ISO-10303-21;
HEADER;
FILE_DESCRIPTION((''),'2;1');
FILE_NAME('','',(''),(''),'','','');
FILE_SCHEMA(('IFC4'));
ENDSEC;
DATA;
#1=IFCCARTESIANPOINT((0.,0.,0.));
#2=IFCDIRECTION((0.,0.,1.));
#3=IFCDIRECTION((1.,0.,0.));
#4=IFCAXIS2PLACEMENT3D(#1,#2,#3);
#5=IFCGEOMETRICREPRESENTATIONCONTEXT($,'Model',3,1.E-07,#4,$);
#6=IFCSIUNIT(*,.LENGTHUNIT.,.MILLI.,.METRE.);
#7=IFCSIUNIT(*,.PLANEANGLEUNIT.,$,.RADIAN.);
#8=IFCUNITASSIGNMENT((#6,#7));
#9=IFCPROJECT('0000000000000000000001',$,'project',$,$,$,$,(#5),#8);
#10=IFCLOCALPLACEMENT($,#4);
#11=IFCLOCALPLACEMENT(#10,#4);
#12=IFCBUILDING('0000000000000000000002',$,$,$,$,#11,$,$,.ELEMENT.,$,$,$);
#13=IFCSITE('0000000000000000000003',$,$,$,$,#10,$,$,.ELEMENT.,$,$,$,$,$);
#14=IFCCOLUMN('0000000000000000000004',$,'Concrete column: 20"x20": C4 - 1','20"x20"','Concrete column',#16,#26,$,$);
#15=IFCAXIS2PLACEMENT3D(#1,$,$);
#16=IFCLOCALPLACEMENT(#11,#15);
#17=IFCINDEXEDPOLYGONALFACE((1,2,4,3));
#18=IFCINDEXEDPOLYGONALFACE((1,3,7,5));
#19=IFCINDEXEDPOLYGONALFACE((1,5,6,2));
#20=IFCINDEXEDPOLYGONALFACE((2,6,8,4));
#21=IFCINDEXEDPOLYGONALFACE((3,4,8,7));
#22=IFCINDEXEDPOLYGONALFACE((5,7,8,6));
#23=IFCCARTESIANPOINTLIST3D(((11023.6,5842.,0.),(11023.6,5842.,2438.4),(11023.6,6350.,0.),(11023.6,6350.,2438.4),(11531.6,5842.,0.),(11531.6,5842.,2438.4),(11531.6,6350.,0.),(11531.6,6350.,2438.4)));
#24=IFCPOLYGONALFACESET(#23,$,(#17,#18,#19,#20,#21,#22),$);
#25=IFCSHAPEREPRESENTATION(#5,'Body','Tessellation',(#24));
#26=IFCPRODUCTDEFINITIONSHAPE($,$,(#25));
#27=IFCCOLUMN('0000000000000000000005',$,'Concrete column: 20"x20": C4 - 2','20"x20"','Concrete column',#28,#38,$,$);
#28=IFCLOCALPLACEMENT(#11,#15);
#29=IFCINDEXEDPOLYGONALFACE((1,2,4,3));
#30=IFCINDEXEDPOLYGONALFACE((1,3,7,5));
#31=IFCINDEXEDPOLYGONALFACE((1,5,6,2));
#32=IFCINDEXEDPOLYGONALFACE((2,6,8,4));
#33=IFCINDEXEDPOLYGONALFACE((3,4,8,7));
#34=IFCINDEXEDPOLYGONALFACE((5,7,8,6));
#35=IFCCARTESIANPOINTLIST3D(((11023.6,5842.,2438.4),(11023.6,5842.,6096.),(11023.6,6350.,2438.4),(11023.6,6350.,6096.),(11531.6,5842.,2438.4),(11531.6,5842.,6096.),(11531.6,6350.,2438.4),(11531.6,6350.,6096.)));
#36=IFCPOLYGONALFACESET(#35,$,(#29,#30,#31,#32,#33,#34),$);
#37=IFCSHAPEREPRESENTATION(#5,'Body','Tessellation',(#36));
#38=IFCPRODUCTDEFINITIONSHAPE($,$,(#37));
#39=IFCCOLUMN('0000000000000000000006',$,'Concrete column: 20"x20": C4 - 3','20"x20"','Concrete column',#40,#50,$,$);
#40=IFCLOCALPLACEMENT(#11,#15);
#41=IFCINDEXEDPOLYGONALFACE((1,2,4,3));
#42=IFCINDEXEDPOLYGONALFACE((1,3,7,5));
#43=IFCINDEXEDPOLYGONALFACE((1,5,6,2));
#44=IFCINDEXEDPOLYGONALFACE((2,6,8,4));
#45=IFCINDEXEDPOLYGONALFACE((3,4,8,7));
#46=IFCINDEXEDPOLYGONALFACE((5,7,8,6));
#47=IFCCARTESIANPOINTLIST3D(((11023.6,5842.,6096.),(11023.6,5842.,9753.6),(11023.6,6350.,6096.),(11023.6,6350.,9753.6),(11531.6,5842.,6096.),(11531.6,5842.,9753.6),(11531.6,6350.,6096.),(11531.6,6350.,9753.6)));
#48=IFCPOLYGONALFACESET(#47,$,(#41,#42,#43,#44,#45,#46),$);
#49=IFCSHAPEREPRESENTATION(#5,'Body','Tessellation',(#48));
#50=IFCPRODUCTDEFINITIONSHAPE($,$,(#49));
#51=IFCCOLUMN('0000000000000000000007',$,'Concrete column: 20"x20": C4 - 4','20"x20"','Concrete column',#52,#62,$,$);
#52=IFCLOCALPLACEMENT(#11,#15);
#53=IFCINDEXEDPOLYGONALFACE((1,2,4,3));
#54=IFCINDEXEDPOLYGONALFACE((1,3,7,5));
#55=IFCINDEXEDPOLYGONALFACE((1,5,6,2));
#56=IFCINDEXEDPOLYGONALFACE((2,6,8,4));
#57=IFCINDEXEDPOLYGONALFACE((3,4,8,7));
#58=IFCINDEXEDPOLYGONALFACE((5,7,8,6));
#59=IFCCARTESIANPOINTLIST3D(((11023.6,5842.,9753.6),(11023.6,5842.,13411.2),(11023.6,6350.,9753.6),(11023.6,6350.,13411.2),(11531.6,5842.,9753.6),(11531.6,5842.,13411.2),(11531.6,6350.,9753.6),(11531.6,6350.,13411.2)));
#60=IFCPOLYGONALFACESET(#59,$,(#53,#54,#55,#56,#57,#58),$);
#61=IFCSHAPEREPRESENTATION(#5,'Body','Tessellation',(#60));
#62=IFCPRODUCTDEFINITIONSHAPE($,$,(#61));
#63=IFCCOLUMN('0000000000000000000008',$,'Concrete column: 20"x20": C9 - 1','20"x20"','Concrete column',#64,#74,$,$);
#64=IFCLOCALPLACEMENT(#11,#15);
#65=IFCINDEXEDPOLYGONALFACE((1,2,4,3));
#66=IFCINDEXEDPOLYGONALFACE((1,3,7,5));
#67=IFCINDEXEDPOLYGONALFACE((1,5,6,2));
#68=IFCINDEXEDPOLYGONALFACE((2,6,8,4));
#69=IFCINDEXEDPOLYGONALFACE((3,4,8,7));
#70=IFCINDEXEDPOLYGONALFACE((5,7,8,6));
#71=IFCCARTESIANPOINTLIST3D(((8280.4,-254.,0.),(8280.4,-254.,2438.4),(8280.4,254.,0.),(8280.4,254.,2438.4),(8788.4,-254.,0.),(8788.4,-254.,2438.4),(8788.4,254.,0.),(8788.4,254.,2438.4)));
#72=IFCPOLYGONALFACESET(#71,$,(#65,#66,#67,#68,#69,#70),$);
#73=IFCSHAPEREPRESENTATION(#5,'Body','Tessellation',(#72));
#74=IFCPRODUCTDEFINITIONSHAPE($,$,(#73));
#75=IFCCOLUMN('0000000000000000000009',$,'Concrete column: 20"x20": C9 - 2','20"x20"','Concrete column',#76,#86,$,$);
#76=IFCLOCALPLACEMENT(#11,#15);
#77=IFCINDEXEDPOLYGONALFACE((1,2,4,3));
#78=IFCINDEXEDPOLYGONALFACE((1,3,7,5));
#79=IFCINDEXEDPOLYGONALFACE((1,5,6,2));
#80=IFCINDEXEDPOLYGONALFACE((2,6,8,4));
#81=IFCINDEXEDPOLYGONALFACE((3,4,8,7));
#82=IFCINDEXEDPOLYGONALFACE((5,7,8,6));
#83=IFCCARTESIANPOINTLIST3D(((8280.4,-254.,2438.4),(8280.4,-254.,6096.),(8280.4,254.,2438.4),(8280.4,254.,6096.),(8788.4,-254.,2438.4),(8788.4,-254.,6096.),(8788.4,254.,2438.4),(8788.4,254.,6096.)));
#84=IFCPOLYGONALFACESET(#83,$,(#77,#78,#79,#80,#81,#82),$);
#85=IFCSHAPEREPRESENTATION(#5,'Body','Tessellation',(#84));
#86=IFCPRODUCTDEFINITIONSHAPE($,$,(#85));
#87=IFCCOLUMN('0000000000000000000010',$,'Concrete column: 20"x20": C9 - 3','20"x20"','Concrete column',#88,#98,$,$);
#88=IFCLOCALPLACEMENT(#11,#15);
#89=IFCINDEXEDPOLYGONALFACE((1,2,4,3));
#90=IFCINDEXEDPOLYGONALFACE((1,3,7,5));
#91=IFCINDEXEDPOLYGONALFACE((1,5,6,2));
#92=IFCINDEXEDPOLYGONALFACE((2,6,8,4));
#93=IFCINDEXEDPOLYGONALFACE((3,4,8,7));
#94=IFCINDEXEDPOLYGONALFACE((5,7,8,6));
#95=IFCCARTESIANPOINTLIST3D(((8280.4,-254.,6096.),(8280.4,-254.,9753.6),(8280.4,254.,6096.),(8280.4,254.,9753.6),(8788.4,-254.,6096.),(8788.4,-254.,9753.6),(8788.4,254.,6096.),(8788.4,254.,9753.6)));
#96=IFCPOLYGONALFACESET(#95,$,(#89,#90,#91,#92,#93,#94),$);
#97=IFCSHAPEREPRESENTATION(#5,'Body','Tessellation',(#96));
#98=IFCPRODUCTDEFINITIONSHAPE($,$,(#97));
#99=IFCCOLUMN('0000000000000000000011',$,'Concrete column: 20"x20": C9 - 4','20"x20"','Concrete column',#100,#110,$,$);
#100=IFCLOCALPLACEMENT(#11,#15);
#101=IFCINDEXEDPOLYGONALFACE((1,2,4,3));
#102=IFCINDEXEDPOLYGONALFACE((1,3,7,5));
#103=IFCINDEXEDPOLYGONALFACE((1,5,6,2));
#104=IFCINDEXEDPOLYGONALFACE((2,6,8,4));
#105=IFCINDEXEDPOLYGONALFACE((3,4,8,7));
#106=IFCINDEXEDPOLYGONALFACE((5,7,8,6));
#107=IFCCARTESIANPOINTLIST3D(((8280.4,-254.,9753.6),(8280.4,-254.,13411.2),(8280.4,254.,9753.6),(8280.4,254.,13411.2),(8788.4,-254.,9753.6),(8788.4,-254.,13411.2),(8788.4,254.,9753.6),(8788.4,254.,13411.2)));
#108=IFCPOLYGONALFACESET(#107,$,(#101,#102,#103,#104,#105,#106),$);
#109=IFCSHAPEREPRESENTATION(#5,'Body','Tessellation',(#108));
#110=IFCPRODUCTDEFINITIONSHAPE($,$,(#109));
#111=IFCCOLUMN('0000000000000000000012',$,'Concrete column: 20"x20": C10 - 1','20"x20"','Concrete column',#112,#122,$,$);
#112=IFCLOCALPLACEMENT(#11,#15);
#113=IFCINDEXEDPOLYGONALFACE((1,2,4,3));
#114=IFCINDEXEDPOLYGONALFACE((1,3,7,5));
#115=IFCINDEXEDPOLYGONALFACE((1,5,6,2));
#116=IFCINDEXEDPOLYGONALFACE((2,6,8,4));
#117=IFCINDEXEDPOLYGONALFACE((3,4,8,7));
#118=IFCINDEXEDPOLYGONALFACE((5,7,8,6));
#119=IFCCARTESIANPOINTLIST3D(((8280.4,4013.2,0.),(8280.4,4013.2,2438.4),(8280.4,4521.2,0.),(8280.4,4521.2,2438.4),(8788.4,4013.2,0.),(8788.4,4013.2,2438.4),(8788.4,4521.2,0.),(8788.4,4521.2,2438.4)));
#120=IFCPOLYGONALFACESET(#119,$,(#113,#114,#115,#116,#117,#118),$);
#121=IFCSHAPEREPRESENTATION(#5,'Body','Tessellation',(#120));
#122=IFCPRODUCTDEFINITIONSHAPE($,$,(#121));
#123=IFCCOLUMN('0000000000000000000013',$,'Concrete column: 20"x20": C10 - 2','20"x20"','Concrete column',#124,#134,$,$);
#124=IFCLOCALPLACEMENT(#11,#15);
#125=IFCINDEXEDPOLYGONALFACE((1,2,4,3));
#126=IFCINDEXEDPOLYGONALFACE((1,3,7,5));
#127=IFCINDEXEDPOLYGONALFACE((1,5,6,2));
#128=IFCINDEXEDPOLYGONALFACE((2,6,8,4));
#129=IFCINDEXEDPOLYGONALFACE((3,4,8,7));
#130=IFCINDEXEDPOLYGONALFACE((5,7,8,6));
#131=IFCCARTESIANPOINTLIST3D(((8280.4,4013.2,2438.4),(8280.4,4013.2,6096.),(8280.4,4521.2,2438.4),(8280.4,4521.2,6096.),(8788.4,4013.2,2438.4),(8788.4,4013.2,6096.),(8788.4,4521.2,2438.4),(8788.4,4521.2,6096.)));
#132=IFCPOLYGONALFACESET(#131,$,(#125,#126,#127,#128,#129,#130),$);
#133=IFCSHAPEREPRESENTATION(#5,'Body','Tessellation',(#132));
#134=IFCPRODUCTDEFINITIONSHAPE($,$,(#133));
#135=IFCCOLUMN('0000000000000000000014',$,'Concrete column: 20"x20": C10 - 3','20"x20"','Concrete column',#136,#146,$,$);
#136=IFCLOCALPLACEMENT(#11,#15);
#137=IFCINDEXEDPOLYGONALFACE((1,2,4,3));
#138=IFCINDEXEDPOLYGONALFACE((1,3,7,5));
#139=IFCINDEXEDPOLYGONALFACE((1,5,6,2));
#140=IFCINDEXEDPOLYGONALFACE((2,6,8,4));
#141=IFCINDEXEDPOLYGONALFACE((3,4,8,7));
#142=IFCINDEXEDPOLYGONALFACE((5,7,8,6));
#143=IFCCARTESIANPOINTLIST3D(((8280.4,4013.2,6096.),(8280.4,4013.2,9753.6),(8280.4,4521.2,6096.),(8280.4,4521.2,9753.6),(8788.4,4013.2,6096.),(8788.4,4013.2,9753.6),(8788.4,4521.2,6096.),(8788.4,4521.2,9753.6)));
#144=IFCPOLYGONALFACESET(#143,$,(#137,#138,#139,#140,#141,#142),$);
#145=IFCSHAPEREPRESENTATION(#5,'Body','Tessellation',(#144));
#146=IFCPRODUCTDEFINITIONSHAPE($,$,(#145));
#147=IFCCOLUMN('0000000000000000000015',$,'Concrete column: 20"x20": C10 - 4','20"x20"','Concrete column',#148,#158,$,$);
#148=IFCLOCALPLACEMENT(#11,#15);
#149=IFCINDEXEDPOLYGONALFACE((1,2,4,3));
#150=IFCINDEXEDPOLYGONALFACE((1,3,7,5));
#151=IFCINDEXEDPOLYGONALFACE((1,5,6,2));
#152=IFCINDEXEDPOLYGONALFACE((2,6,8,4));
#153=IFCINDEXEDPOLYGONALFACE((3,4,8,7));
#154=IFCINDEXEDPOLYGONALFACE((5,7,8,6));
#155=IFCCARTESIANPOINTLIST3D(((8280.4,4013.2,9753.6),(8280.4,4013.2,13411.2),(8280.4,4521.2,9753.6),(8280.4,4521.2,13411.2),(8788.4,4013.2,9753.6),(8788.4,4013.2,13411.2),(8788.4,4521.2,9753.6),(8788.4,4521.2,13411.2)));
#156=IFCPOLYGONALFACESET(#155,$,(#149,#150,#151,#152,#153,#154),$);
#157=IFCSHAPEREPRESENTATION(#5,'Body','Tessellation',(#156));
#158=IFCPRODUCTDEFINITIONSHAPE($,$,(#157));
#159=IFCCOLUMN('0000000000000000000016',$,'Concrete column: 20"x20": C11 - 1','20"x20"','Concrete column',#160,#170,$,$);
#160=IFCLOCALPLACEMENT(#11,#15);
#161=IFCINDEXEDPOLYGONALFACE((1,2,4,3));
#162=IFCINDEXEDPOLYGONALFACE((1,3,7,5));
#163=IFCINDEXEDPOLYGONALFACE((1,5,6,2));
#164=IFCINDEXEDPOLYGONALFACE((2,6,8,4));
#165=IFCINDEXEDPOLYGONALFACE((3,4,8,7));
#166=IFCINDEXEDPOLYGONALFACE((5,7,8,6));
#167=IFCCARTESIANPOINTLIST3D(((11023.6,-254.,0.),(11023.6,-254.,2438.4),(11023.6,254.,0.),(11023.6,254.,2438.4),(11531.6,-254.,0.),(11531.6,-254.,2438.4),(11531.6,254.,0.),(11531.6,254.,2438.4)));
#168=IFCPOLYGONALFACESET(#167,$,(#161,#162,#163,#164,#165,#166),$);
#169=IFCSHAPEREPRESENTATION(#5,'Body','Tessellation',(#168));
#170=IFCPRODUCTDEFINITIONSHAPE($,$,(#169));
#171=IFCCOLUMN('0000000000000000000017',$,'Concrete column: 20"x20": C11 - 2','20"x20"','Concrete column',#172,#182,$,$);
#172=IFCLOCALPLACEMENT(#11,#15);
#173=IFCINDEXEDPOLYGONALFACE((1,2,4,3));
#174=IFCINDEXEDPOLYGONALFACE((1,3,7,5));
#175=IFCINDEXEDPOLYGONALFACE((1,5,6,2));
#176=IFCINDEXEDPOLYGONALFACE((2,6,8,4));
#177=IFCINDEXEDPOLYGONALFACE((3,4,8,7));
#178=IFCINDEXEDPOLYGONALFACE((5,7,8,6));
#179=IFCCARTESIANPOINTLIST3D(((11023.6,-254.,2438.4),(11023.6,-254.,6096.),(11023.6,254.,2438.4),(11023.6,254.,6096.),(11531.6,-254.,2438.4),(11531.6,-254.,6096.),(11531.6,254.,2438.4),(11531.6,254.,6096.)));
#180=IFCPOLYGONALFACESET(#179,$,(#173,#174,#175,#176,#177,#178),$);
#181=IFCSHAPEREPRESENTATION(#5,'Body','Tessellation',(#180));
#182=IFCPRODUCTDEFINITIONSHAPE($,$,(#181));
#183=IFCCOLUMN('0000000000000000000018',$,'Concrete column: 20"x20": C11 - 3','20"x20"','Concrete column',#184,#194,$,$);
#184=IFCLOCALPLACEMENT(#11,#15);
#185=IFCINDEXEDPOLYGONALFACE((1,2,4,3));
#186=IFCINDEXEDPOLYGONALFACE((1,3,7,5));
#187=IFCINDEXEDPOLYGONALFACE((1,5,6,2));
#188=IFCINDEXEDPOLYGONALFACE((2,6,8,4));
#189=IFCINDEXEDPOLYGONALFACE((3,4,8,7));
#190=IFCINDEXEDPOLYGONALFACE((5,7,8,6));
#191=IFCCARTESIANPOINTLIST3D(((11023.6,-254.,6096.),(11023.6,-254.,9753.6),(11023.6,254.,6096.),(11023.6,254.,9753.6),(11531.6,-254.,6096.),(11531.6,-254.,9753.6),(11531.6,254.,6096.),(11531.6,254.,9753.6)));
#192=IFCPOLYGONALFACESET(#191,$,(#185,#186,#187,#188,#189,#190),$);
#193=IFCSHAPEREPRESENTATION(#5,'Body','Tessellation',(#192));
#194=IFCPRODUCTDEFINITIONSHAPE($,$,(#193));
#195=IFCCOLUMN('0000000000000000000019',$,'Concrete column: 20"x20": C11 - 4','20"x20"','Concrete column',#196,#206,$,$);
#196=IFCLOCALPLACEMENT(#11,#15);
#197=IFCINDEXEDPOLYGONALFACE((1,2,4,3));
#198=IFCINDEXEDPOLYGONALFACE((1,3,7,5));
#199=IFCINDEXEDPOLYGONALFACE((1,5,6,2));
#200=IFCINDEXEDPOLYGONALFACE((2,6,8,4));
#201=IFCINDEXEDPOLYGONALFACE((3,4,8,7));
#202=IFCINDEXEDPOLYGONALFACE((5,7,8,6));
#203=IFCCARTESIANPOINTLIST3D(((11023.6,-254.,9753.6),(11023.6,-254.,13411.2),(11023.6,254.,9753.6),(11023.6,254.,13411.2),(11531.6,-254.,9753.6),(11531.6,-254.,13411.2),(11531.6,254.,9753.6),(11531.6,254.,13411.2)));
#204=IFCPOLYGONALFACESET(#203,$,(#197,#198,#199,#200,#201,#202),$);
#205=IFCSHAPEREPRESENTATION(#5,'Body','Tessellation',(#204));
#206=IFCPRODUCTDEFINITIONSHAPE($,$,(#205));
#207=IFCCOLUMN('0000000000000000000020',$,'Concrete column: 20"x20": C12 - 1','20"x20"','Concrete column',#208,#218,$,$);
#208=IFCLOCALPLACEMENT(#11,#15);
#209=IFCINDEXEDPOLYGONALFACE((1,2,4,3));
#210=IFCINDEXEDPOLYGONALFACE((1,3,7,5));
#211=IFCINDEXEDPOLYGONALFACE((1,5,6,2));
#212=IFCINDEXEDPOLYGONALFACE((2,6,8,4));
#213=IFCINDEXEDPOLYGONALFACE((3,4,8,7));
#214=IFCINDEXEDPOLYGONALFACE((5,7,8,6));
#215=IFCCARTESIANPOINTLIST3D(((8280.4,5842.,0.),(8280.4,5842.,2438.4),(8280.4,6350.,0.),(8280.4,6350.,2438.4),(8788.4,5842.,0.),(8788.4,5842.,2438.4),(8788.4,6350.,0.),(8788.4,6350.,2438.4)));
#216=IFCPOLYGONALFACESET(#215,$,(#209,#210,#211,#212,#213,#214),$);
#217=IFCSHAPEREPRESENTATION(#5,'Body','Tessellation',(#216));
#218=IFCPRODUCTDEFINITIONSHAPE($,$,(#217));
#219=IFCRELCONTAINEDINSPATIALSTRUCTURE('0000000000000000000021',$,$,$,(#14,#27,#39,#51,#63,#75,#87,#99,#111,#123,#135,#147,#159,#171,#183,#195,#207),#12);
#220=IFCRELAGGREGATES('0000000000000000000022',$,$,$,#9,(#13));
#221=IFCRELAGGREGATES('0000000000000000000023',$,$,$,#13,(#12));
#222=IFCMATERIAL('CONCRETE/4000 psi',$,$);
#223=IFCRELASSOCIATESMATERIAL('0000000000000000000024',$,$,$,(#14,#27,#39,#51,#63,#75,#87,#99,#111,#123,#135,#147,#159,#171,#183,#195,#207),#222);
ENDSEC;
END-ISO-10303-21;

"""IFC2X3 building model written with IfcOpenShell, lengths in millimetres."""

from ifc_helpers import new_model, si_unit, frame, origin_with_axes, origin_2d_with_axis, place, context, project, spatial, rectangle, extrude, material, element, save


model = new_model("IFC2X3")

# Units and contexts
model_context = context("Model", 3, precision=1e-07, world=origin_with_axes())
ifc_project = project(units=[si_unit("LENGTHUNIT", "METRE", prefix="MILLI"), si_unit("PLANEANGLEUNIT", "RADIAN")], contexts=[model_context])

# Site, building
site_placement = place(None, origin_with_axes())
site = spatial("IfcSite", under=ifc_project, at=site_placement, CompositionType="ELEMENT")
building_placement = place(site_placement, origin_with_axes())
building = spatial("IfcBuilding", under=site, at=building_placement, CompositionType="ELEMENT")

# Columns
ifc_material = material(Name="CONCRETE/4000 psi")
column_1_placement = place(building_placement, frame((11277.6, 6096.0, 0.0), z_axis=(0.0, 0.0, 1.0), x_axis=(1.0, 0.0, 0.0)))
element("IfcColumn", 1, at=column_1_placement, inside=building, material=ifc_material, Name="Concrete column: 20\"x20\": C4 - 1", Description="20\"x20\"", ObjectType="Concrete column", context=model_context, shape_type="SweptSolid", body=[
    extrude(rectangle(XDim=508.0, YDim=508.0, at=origin_2d_with_axis()), origin_with_axes(), (0.0, 0.0, 1.0), 2438.4),
])
for number, where, z_axis, x_axis, name in (
    (2, (11277.6, 6096.0, 2438.4), (0.0, 0.0, 1.0), (1.0, 0.0, 0.0), "Concrete column: 20\"x20\": C4 - 2"),
    (3, (11277.6, 6096.0, 6096.0), (0.0, 0.0, 1.0), (1.0, 0.0, 0.0), "Concrete column: 20\"x20\": C4 - 3"),
    (4, (11277.6, 6096.0, 9753.6), (0.0, 0.0, 1.0), (1.0, 0.0, 0.0), "Concrete column: 20\"x20\": C4 - 4"),
):
    element("IfcColumn", number, at=place(building_placement, frame(where, z_axis=z_axis, x_axis=x_axis)), inside=building, material=ifc_material, Name=name, Description="20\"x20\"", ObjectType="Concrete column", context=model_context, shape_type="SweptSolid", body=[
        extrude(rectangle(XDim=508.0, YDim=508.0, at=origin_2d_with_axis()), origin_with_axes(), (0.0, 0.0, 1.0), 3657.6),
    ])
column_2_placement = place(building_placement, frame((8534.4, 0.0, 0.0), z_axis=(0.0, 0.0, 1.0), x_axis=(1.0, 0.0, 0.0)))
element("IfcColumn", 5, at=column_2_placement, inside=building, material=ifc_material, Name="Concrete column: 20\"x20\": C9 - 1", Description="20\"x20\"", ObjectType="Concrete column", context=model_context, shape_type="SweptSolid", body=[
    extrude(rectangle(XDim=508.0, YDim=508.0, at=origin_2d_with_axis()), origin_with_axes(), (0.0, 0.0, 1.0), 2438.4),
])
for number, where, z_axis, x_axis, name in (
    (6, (8534.4, 0.0, 2438.4), (0.0, 0.0, 1.0), (1.0, 0.0, 0.0), "Concrete column: 20\"x20\": C9 - 2"),
    (7, (8534.4, 0.0, 6096.0), (0.0, 0.0, 1.0), (1.0, 0.0, 0.0), "Concrete column: 20\"x20\": C9 - 3"),
    (8, (8534.4, 0.0, 9753.6), (0.0, 0.0, 1.0), (1.0, 0.0, 0.0), "Concrete column: 20\"x20\": C9 - 4"),
):
    element("IfcColumn", number, at=place(building_placement, frame(where, z_axis=z_axis, x_axis=x_axis)), inside=building, material=ifc_material, Name=name, Description="20\"x20\"", ObjectType="Concrete column", context=model_context, shape_type="SweptSolid", body=[
        extrude(rectangle(XDim=508.0, YDim=508.0, at=origin_2d_with_axis()), origin_with_axes(), (0.0, 0.0, 1.0), 3657.6),
    ])
column_3_placement = place(building_placement, frame((8534.4, 4267.2, 0.0), z_axis=(0.0, 0.0, 1.0), x_axis=(1.0, 0.0, 0.0)))
element("IfcColumn", 9, at=column_3_placement, inside=building, material=ifc_material, Name="Concrete column: 20\"x20\": C10 - 1", Description="20\"x20\"", ObjectType="Concrete column", context=model_context, shape_type="SweptSolid", body=[
    extrude(rectangle(XDim=508.0, YDim=508.0, at=origin_2d_with_axis()), origin_with_axes(), (0.0, 0.0, 1.0), 2438.4),
])
for number, where, z_axis, x_axis, name in (
    (10, (8534.4, 4267.2, 2438.4), (0.0, 0.0, 1.0), (1.0, 0.0, 0.0), "Concrete column: 20\"x20\": C10 - 2"),
    (11, (8534.4, 4267.2, 6096.0), (0.0, 0.0, 1.0), (1.0, 0.0, 0.0), "Concrete column: 20\"x20\": C10 - 3"),
    (12, (8534.4, 4267.2, 9753.6), (0.0, 0.0, 1.0), (1.0, 0.0, 0.0), "Concrete column: 20\"x20\": C10 - 4"),
):
    element("IfcColumn", number, at=place(building_placement, frame(where, z_axis=z_axis, x_axis=x_axis)), inside=building, material=ifc_material, Name=name, Description="20\"x20\"", ObjectType="Concrete column", context=model_context, shape_type="SweptSolid", body=[
        extrude(rectangle(XDim=508.0, YDim=508.0, at=origin_2d_with_axis()), origin_with_axes(), (0.0, 0.0, 1.0), 3657.6),
    ])
column_4_placement = place(building_placement, frame((11277.6, 0.0, 0.0), z_axis=(0.0, 0.0, 1.0), x_axis=(1.0, 0.0, 0.0)))
element("IfcColumn", 13, at=column_4_placement, inside=building, material=ifc_material, Name="Concrete column: 20\"x20\": C11 - 1", Description="20\"x20\"", ObjectType="Concrete column", context=model_context, shape_type="SweptSolid", body=[
    extrude(rectangle(XDim=508.0, YDim=508.0, at=origin_2d_with_axis()), origin_with_axes(), (0.0, 0.0, 1.0), 2438.4),
])
for number, where, z_axis, x_axis, name in (
    (14, (11277.6, 0.0, 2438.4), (0.0, 0.0, 1.0), (1.0, 0.0, 0.0), "Concrete column: 20\"x20\": C11 - 2"),
    (15, (11277.6, 0.0, 6096.0), (0.0, 0.0, 1.0), (1.0, 0.0, 0.0), "Concrete column: 20\"x20\": C11 - 3"),
    (16, (11277.6, 0.0, 9753.6), (0.0, 0.0, 1.0), (1.0, 0.0, 0.0), "Concrete column: 20\"x20\": C11 - 4"),
):
    element("IfcColumn", number, at=place(building_placement, frame(where, z_axis=z_axis, x_axis=x_axis)), inside=building, material=ifc_material, Name=name, Description="20\"x20\"", ObjectType="Concrete column", context=model_context, shape_type="SweptSolid", body=[
        extrude(rectangle(XDim=508.0, YDim=508.0, at=origin_2d_with_axis()), origin_with_axes(), (0.0, 0.0, 1.0), 3657.6),
    ])
column_5_placement = place(building_placement, frame((8534.4, 6096.0, 0.0), z_axis=(0.0, 0.0, 1.0), x_axis=(1.0, 0.0, 0.0)))
element("IfcColumn", 17, at=column_5_placement, inside=building, material=ifc_material, Name="Concrete column: 20\"x20\": C12 - 1", Description="20\"x20\"", ObjectType="Concrete column", context=model_context, shape_type="SweptSolid", body=[
    extrude(rectangle(XDim=508.0, YDim=508.0, at=origin_2d_with_axis()), origin_with_axes(), (0.0, 0.0, 1.0), 2438.4),
])

save(model, "model.ifc")
